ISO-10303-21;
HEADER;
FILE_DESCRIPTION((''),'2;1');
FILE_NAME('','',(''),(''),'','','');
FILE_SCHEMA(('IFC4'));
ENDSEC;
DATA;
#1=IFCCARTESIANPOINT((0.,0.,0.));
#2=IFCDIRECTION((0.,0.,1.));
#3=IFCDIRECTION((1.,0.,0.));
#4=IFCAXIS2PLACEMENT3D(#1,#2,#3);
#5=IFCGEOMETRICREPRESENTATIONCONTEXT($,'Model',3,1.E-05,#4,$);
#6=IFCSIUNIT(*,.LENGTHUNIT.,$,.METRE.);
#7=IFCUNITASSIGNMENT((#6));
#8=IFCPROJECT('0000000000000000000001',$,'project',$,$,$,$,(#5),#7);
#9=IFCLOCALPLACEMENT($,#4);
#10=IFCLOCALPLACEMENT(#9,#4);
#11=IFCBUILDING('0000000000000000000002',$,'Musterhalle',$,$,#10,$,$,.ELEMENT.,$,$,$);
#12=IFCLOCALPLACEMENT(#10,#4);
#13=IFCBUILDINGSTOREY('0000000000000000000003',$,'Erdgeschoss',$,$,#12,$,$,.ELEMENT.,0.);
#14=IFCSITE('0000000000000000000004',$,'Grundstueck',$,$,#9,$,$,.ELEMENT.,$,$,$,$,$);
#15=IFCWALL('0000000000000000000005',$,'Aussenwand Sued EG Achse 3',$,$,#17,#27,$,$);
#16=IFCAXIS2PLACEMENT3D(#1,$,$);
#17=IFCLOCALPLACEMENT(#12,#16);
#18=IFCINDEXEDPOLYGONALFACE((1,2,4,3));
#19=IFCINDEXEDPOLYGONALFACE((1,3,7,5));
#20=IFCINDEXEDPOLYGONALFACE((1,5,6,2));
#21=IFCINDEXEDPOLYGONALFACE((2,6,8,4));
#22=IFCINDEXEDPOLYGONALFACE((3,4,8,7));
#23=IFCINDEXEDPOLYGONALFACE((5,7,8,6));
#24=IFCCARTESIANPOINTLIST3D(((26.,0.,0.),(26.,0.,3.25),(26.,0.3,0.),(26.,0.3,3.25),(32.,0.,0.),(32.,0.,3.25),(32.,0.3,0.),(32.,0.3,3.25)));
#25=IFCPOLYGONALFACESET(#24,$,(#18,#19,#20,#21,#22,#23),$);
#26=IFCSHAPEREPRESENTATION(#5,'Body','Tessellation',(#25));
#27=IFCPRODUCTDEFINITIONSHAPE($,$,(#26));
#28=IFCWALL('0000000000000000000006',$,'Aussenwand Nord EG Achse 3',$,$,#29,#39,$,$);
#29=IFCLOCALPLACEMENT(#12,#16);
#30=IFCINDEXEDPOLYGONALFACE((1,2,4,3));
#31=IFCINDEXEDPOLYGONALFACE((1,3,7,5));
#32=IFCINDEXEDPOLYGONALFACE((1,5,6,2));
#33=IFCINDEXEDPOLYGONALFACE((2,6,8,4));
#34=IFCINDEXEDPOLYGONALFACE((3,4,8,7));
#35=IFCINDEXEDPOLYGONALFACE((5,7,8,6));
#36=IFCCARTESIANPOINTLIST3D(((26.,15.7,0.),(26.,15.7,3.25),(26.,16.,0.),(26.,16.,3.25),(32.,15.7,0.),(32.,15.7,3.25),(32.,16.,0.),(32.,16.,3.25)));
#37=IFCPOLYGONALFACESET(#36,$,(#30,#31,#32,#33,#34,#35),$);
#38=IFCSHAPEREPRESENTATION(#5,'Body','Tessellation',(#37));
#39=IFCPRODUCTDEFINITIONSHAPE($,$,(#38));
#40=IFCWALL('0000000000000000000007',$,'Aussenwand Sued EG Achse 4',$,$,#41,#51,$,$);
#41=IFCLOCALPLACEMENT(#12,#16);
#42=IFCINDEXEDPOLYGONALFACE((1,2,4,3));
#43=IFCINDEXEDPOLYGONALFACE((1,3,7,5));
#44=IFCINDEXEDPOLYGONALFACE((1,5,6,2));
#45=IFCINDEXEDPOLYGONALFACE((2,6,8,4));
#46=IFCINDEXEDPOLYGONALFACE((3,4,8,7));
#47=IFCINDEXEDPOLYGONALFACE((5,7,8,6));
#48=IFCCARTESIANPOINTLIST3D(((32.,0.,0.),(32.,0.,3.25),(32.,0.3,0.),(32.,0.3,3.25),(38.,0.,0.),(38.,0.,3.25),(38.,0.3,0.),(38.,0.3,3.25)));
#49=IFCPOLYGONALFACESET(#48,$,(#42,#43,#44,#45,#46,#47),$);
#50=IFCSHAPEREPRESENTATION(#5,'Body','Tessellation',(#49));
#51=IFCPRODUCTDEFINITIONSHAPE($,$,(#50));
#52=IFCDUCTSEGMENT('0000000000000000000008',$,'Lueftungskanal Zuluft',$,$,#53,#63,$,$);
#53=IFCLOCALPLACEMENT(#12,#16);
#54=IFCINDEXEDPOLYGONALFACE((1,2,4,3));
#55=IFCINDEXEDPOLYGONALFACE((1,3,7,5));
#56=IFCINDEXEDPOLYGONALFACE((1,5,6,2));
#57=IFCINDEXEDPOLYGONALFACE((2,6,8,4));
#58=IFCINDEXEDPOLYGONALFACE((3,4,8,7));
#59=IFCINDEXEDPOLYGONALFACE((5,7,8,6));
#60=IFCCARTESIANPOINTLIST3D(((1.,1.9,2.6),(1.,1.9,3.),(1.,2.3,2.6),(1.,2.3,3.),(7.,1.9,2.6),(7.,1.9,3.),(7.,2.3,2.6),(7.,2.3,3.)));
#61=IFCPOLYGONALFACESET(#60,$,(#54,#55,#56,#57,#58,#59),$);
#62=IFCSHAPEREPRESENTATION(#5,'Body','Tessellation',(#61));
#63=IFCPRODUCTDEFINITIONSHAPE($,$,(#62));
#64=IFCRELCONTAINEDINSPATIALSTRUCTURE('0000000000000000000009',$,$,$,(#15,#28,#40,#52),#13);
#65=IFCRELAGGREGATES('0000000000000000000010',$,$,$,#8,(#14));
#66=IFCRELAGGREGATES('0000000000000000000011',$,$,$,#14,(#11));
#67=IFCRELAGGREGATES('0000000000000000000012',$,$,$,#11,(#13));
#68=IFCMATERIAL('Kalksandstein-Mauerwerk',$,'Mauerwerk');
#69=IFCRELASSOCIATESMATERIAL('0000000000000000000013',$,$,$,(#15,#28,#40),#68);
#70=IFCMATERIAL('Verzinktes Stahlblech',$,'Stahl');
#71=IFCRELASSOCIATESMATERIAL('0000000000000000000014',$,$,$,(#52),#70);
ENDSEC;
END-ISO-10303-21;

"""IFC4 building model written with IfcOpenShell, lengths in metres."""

from ifc_helpers import new_model, si_unit, frame, origin_with_axes, origin_2d, place, context, project, spatial, rectangle, extrude, material, element, save


model = new_model("IFC4")

# Units and contexts
model_context = context("Model", 3, precision=1e-05, world=origin_with_axes())
ifc_project = project(units=[si_unit("LENGTHUNIT", "METRE")], contexts=[model_context])

# Site, building, storey
site_placement = place(None, origin_with_axes())
site = spatial("IfcSite", under=ifc_project, at=site_placement, Name="Grundstueck", CompositionType="ELEMENT")
building_placement = place(site_placement, origin_with_axes())
building = spatial("IfcBuilding", under=site, at=building_placement, Name="Musterhalle", CompositionType="ELEMENT")
storey_placement = place(building_placement, origin_with_axes())
storey = spatial("IfcBuildingStorey", under=building, at=storey_placement, Name="Erdgeschoss", CompositionType="ELEMENT", Elevation=0.0)

# Shared definitions
placement = place(storey_placement, origin_with_axes())

# Walls
ifc_material_1 = material(Name="Kalksandstein-Mauerwerk", Category="Mauerwerk")
element("IfcWall", 1, at=placement, inside=storey, material=ifc_material_1, Name="Aussenwand Sued EG Achse 3", context=model_context, shape_type="SweptSolid", body=[
    extrude(rectangle(XDim=6.0, YDim=0.3, at=origin_2d()), frame((29.0, 0.15, 0.0), z_axis=(0.0, 0.0, 1.0), x_axis=(1.0, 0.0, 0.0)), (0.0, 0.0, 1.0), 3.25),
])
element("IfcWall", 2, at=placement, inside=storey, material=ifc_material_1, Name="Aussenwand Nord EG Achse 3", context=model_context, shape_type="SweptSolid", body=[
    extrude(rectangle(XDim=6.0, YDim=0.3, at=origin_2d()), frame((29.0, 15.85, 0.0), z_axis=(0.0, 0.0, 1.0), x_axis=(1.0, 0.0, 0.0)), (0.0, 0.0, 1.0), 3.25),
])
element("IfcWall", 3, at=placement, inside=storey, material=ifc_material_1, Name="Aussenwand Sued EG Achse 4", context=model_context, shape_type="SweptSolid", body=[
    extrude(rectangle(XDim=6.0, YDim=0.3, at=origin_2d()), frame((35.0, 0.15, 0.0), z_axis=(0.0, 0.0, 1.0), x_axis=(1.0, 0.0, 0.0)), (0.0, 0.0, 1.0), 3.25),
])

# Duct segment
ifc_material_2 = material(Name="Verzinktes Stahlblech", Category="Stahl")
element("IfcDuctSegment", 4, at=placement, inside=storey, material=ifc_material_2, Name="Lueftungskanal Zuluft", context=model_context, shape_type="SweptSolid", body=[
    extrude(rectangle(XDim=6.0, YDim=0.4, at=origin_2d()), frame((4.0, 2.1, 2.6), z_axis=(0.0, 0.0, 1.0), x_axis=(1.0, 0.0, 0.0)), (0.0, 0.0, 1.0), 0.4),
])

save(model, "model.ifc")
